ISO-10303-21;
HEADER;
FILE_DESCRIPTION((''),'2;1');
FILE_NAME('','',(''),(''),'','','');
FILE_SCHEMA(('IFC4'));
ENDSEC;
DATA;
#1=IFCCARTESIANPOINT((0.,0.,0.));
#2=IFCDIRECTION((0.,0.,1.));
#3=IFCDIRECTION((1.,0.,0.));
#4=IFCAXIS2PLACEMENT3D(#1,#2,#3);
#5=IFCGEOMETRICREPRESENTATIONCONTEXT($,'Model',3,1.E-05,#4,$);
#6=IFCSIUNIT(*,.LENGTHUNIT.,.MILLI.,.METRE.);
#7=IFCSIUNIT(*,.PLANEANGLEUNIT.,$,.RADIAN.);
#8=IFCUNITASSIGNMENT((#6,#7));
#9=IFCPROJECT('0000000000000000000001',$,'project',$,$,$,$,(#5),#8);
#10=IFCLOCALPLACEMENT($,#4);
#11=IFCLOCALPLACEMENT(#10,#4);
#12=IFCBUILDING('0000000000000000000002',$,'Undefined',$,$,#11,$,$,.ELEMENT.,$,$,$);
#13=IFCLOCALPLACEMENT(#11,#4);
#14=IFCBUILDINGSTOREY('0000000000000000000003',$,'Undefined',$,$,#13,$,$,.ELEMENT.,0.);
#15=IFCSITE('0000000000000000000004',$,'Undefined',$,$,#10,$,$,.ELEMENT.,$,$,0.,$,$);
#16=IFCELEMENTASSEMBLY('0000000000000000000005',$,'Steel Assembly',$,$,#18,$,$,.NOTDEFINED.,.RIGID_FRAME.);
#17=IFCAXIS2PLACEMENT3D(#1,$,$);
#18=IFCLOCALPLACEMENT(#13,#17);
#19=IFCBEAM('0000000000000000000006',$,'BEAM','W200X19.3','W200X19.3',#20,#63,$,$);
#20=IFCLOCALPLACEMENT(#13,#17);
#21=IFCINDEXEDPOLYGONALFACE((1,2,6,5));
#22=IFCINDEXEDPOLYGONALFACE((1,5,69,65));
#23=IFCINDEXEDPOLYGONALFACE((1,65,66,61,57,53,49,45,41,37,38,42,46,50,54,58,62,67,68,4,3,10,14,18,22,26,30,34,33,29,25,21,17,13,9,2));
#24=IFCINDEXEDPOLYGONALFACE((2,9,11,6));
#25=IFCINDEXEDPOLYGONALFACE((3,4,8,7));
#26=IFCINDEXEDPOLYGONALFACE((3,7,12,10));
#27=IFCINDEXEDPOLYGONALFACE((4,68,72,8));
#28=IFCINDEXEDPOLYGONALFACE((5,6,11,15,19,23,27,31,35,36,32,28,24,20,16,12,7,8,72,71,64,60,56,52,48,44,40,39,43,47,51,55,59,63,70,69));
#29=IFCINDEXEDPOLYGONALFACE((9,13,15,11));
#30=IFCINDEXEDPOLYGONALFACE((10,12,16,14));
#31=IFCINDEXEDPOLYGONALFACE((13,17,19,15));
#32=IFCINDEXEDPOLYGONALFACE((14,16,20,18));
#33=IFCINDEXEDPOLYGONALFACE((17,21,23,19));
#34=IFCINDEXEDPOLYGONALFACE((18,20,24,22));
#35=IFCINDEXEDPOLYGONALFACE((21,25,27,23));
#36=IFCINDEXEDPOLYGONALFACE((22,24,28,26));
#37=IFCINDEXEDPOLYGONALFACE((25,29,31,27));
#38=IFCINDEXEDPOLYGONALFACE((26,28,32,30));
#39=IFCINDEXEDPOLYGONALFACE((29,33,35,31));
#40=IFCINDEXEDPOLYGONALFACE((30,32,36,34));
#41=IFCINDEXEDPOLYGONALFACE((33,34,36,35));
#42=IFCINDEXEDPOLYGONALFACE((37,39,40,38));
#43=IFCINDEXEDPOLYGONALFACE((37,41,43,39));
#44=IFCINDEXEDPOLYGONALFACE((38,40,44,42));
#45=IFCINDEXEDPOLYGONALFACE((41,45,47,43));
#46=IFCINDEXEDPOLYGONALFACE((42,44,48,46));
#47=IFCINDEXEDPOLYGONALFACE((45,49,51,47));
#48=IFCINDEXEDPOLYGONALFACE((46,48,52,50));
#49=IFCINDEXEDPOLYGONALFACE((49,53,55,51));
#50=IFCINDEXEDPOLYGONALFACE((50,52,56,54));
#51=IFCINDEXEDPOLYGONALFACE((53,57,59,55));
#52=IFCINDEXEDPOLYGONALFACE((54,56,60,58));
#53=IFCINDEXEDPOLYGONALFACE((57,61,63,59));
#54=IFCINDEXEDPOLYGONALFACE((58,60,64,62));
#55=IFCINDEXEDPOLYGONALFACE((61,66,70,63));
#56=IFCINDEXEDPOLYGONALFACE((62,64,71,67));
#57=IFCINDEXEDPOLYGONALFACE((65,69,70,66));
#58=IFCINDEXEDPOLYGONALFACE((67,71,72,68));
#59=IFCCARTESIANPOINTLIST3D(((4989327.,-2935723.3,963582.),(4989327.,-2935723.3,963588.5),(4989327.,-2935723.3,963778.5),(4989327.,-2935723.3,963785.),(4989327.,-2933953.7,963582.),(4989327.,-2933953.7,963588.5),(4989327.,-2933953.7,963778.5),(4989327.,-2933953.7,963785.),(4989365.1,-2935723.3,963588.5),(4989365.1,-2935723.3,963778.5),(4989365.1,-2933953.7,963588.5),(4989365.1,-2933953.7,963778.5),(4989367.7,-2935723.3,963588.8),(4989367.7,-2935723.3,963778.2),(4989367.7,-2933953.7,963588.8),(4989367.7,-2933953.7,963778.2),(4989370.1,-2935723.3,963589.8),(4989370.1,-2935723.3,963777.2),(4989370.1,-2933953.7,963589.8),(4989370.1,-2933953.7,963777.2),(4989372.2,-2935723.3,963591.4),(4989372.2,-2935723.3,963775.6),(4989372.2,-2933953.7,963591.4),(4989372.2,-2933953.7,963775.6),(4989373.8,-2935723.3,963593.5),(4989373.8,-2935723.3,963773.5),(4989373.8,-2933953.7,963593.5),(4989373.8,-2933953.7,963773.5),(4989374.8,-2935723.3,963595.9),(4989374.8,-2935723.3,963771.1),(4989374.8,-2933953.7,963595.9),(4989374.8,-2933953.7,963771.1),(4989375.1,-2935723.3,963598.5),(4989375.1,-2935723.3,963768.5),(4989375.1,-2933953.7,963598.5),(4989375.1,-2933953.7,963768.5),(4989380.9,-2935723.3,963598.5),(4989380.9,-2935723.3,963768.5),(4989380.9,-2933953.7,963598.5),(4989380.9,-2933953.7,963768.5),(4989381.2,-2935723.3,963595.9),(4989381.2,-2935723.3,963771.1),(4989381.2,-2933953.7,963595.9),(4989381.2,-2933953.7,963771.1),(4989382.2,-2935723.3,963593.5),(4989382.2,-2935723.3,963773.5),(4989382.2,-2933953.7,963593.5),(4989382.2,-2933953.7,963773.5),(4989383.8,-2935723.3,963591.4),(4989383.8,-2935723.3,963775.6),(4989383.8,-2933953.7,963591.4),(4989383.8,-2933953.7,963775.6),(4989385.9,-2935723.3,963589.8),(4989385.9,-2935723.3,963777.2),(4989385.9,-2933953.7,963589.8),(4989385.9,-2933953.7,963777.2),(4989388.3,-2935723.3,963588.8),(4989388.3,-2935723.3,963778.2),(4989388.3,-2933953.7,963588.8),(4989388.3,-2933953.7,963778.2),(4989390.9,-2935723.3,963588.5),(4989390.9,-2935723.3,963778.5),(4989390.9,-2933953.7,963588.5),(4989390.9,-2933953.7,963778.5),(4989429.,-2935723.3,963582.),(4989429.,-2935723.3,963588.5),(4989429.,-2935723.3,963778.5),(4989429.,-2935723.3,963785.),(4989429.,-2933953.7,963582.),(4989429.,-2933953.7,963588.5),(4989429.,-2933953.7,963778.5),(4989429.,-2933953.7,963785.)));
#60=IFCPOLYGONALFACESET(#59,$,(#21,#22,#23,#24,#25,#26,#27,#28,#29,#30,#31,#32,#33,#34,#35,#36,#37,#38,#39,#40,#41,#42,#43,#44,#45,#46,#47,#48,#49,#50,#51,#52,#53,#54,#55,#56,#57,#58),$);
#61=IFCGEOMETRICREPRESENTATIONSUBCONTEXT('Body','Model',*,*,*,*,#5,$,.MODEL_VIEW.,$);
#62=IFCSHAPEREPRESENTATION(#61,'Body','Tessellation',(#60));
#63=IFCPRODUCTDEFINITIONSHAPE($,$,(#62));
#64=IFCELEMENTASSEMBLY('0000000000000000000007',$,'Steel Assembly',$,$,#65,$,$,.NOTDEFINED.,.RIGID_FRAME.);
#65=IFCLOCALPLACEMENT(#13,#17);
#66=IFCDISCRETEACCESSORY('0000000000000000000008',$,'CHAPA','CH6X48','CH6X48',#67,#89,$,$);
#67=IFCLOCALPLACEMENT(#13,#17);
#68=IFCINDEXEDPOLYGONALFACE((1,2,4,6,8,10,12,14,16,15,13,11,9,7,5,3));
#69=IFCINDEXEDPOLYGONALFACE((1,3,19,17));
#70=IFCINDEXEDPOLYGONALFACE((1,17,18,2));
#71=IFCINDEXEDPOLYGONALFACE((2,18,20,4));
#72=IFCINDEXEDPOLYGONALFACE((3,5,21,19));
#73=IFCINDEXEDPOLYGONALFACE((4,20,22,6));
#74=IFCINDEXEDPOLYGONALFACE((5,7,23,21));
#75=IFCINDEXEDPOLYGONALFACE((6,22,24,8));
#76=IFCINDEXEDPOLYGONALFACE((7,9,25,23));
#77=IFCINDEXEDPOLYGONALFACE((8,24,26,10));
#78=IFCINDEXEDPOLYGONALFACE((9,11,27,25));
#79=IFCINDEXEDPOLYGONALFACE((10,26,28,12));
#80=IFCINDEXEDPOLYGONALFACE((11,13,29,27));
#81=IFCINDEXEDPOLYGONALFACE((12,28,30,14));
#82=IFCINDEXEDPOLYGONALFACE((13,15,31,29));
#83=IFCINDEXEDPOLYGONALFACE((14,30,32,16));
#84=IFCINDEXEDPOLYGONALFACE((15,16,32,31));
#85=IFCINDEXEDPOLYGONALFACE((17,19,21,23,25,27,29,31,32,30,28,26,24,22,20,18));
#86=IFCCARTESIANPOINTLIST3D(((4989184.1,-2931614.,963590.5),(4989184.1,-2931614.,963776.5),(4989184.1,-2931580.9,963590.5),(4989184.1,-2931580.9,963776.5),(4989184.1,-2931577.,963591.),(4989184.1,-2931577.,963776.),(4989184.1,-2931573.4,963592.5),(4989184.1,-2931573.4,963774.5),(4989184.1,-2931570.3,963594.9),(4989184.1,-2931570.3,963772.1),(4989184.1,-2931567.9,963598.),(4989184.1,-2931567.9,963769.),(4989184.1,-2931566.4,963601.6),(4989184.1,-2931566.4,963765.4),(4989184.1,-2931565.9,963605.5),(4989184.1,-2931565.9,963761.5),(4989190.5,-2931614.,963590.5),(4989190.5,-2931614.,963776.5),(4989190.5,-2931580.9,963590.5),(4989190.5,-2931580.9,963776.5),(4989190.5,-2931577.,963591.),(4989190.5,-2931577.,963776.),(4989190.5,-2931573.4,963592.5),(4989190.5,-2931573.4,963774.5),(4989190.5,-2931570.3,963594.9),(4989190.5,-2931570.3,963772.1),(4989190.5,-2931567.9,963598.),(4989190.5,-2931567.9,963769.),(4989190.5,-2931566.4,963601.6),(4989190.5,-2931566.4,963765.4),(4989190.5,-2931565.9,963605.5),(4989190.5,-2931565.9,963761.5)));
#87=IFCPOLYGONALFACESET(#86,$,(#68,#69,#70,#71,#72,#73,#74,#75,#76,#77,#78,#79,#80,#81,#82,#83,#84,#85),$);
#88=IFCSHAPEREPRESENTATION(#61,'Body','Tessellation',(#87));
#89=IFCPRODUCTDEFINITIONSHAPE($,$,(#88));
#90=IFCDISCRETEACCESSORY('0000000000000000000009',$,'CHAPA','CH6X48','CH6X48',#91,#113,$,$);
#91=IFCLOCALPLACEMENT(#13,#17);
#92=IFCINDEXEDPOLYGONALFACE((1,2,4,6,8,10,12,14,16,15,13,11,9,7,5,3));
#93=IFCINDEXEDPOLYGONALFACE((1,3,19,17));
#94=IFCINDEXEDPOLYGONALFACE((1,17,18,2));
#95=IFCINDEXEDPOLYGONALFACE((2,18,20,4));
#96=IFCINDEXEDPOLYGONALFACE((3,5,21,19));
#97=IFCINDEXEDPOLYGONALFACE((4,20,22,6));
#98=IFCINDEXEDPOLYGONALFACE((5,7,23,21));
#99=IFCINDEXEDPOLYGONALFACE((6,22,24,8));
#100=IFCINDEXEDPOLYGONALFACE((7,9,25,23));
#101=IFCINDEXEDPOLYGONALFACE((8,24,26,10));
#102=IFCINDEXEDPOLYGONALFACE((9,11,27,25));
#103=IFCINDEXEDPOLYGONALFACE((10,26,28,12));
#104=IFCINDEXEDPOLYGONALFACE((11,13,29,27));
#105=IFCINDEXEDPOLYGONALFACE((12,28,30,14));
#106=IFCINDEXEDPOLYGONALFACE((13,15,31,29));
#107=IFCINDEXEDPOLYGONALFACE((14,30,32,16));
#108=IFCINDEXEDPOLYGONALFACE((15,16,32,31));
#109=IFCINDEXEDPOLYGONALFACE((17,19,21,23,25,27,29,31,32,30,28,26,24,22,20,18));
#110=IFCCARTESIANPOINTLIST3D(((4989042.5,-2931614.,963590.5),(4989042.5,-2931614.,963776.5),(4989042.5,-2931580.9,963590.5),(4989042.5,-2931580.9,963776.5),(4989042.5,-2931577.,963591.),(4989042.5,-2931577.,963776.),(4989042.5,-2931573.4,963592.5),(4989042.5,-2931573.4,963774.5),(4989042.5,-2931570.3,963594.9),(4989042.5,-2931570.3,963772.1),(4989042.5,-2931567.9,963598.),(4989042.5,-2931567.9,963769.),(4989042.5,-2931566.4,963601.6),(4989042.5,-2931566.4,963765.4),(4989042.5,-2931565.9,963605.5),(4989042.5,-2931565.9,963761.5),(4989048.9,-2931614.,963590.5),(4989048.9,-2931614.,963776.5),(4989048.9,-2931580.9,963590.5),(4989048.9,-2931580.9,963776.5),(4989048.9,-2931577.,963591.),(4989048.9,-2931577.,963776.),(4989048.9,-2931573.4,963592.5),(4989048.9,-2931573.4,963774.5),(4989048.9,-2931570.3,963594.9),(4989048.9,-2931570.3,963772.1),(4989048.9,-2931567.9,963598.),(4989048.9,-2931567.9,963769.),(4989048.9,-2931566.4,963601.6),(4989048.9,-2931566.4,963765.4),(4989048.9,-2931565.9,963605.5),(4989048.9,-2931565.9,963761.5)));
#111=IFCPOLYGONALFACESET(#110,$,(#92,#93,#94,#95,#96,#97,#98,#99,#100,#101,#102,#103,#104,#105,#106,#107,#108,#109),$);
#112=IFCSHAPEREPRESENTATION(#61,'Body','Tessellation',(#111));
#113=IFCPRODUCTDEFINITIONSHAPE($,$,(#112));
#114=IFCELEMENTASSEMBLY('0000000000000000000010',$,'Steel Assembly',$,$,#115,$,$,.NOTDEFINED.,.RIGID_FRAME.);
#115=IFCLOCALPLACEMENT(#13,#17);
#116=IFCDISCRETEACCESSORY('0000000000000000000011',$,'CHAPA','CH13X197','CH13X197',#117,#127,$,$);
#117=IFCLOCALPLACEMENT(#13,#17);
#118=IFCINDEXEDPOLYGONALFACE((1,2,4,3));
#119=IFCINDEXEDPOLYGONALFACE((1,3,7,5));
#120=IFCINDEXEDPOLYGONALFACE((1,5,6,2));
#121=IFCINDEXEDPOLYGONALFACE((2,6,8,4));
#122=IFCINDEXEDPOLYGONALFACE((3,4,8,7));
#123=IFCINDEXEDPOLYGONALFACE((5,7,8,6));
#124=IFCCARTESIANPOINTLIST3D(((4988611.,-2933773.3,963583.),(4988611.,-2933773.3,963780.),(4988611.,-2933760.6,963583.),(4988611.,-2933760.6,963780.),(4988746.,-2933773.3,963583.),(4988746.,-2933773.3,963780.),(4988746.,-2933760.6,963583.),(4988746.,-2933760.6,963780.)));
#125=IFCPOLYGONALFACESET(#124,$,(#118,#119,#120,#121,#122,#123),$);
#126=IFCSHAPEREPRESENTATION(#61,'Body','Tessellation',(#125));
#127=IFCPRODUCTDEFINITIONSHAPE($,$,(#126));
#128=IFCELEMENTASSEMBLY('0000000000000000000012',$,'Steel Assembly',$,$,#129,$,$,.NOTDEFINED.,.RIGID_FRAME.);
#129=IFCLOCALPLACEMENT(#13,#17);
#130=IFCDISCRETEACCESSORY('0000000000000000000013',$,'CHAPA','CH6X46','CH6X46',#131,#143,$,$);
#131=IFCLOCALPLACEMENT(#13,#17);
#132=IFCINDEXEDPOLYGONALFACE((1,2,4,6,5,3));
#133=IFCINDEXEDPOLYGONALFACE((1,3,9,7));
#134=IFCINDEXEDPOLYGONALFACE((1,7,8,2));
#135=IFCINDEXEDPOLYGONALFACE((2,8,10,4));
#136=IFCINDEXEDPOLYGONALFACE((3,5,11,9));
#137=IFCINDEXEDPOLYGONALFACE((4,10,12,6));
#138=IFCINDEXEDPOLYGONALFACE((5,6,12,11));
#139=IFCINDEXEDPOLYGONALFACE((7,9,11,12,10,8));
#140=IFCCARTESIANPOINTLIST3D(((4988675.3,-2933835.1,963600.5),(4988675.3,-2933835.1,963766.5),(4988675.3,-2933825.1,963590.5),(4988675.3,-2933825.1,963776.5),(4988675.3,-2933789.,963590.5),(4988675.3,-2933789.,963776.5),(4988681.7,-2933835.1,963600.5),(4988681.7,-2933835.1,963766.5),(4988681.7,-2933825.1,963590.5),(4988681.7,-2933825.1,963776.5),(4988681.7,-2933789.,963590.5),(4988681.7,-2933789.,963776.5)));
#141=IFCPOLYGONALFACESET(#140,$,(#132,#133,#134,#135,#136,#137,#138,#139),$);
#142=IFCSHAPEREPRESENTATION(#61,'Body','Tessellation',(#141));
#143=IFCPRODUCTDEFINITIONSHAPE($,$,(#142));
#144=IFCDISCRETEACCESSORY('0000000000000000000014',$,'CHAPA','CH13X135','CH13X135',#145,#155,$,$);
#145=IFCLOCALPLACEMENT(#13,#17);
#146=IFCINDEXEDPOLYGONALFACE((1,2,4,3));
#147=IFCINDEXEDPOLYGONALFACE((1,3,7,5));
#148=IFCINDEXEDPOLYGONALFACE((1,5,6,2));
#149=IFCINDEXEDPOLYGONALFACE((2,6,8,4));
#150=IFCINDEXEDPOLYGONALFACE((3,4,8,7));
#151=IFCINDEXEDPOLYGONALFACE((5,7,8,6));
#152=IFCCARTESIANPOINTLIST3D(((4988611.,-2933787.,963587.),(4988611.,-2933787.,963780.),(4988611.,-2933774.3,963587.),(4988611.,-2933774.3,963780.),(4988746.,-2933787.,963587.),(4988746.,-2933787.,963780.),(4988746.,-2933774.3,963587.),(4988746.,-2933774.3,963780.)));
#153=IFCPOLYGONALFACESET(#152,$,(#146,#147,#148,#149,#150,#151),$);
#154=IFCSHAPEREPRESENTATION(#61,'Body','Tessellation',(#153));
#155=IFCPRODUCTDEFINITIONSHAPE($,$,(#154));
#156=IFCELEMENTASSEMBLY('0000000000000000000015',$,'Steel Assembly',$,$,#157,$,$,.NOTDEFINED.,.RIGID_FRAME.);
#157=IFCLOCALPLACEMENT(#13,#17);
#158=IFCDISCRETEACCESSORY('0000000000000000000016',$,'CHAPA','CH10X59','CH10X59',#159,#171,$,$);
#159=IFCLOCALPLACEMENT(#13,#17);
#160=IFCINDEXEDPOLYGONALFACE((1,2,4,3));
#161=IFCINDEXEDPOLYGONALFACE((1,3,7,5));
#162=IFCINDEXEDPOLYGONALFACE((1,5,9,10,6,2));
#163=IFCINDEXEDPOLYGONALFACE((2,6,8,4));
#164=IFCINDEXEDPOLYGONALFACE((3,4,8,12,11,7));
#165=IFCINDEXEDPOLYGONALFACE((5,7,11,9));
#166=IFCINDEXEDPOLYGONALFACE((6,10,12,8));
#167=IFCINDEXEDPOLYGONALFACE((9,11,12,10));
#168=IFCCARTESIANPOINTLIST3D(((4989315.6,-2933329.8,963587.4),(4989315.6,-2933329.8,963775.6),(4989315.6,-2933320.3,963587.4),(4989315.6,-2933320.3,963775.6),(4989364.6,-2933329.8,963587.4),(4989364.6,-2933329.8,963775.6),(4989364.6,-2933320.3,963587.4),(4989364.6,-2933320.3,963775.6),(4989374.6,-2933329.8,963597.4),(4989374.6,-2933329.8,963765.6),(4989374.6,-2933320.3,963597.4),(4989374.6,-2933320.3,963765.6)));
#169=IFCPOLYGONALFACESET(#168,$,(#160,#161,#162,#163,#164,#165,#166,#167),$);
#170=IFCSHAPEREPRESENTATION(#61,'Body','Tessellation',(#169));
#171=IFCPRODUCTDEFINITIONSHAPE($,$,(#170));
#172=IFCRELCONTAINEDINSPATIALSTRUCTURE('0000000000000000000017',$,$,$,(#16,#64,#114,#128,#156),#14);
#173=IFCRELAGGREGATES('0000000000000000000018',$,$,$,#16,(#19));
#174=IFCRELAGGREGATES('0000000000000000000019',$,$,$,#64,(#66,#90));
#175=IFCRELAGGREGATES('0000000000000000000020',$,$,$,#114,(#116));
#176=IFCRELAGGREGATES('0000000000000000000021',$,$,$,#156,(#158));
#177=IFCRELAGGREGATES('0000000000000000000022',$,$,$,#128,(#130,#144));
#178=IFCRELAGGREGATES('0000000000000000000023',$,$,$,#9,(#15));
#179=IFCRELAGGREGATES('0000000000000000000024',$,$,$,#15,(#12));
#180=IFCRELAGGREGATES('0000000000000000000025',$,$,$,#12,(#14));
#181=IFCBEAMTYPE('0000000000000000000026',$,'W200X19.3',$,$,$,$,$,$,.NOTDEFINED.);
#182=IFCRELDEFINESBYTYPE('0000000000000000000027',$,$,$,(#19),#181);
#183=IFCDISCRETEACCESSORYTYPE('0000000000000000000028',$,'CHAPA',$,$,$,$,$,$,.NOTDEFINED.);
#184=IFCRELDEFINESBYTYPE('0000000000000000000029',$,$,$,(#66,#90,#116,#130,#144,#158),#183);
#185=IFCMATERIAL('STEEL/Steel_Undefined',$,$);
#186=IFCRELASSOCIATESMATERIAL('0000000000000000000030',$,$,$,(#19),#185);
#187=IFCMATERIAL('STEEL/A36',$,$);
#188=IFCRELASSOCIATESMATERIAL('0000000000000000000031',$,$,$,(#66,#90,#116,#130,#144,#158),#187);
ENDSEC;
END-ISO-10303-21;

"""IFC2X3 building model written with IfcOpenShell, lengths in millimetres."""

from ifc_helpers import new_model, si_unit, frame, frame_2d, origin_with_axes, origin_2d_with_axis, place, context, subcontext, project, spatial, polyline, circle_curve, parameter, trimmed, segment, composite_curve, i_section, outline, extrude, clip, halfspace, material, type_object, element, aggregate, save


model = new_model("IFC2X3")

# Units and contexts
model_context = context("Model", 3, precision=1e-05, world=origin_with_axes())
body_context = subcontext(model_context, "Body", "Model", "MODEL_VIEW")
ifc_project = project(units=[si_unit("LENGTHUNIT", "METRE", prefix="MILLI"), si_unit("PLANEANGLEUNIT", "RADIAN")], contexts=[model_context])

# Site, building, storey
site_placement = place(None, origin_with_axes())
site = spatial("IfcSite", under=ifc_project, at=site_placement, Name="Undefined", CompositionType="ELEMENT", RefElevation=0.0)
building_placement = place(site_placement, origin_with_axes())
building = spatial("IfcBuilding", under=site, at=building_placement, Name="Undefined", CompositionType="ELEMENT")
storey_placement = place(building_placement, origin_with_axes())
storey = spatial("IfcBuildingStorey", under=building, at=storey_placement, Name="Undefined", CompositionType="ELEMENT", Elevation=0.0)

# Shared definitions
ifc_material_1 = material(Name="STEEL/Steel_Undefined")

# Element assembly, beam
assembly_1_placement = place(storey_placement, origin_with_axes())
assembly_1 = element("IfcElementAssembly", 1, at=assembly_1_placement, inside=storey, Name="Steel Assembly", AssemblyPlace="NOTDEFINED", PredefinedType="RIGID_FRAME")
beam_type = type_object("IfcBeamType", Name="W200X19.3", PredefinedType="NOTDEFINED")
beam_placement = place(assembly_1_placement, frame((4989378.0, -2933838.5, 963683.5), z_axis=(0.0, 0.0, -1.0), x_axis=(0.0, -1.0, 0.0)))
beam = element("IfcBeam", 2, at=beam_placement, type_object=beam_type, material=ifc_material_1, Name="BEAM", Description="W200X19.3", ObjectType="W200X19.3", context=body_context, shape_type="Clipping", body=[
    clip(clip(clip(clip(extrude(i_section(OverallWidth=102.0, OverallDepth=203.0, WebThickness=5.8, FlangeThickness=6.5, FilletRadius=10.0, at=origin_2d_with_axis()), frame((1884.8, 0.0, 0.0), z_axis=(-1.0, 0.0, 0.0), x_axis=(0.0, -1.0, 0.0)), (0.0, 0.0, 1.0), 1769.6), halfspace(frame((112.5, -51.0, 101.5), z_axis=(-1.0, 0.0, 0.0), x_axis=(0.0, 0.0, -1.0)), False)), halfspace(frame((1887.5, 51.0, 101.5), z_axis=(1.0, 0.0, 0.0), x_axis=(0.0, 0.0, -1.0)), False)), halfspace(frame((1884.8, 0.0, 101.5), z_axis=(-1.0, 0.0, 0.0), x_axis=(0.0, -1.0, 0.0)), True)), halfspace(frame((115.2, 0.0, 101.5), z_axis=(1.0, 0.0, 0.0), x_axis=(0.0, 1.0, 0.0)), True)),
])
aggregate(assembly_1, [beam])

# Element assembly, discrete accessories
assembly_2_placement = place(storey_placement, origin_with_axes())
assembly_2 = element("IfcElementAssembly", 3, at=assembly_2_placement, inside=storey, Name="Steel Assembly", AssemblyPlace="NOTDEFINED", PredefinedType="RIGID_FRAME")
ifc_material_2 = material(Name="STEEL/A36")
discrete_accessory_type_1 = type_object("IfcDiscreteAccessoryType", Name="CHAPA")
discrete_accessory_1_placement = place(assembly_2_placement, frame((4989187.3, -2931614.0, 963590.5), z_axis=(1.0, 0.0, 0.0), x_axis=(0.0, 1.0, 0.0)))
discrete_accessory_1 = element("IfcDiscreteAccessory", 4, at=discrete_accessory_1_placement, type_object=discrete_accessory_type_1, material=ifc_material_2, Name="CHAPA", Description="CH6X48", ObjectType="CH6X48", context=body_context, shape_type="SweptSolid", body=[
    extrude(outline(composite_curve([segment(polyline([(0.0, 0.0), (33.1, 0.0)]), True, "CONTINUOUS"), segment(trimmed(circle_curve(frame_2d((33.1, 15.0), x_axis=(0.0, -1.0)), 15.0), [parameter(0.0)], [parameter(1.570796)], True, "PARAMETER"), True, "CONTINUOUS"), segment(polyline([(48.1, 15.0), (48.1, 171.0)]), True, "CONTINUOUS"), segment(trimmed(circle_curve(frame_2d((33.1, 171.0), x_axis=(1.0, 0.0)), 15.0), [parameter(0.0)], [parameter(1.570796)], True, "PARAMETER"), True, "CONTINUOUS"), segment(polyline([(33.1, 186.0), (0.0, 186.0), (0.0, 0.0)]), True, "DISCONTINUOUS")], self_intersect=False)), frame((0.0, 0.0, -3.2), z_axis=(0.0, 0.0, 1.0), x_axis=(1.0, 0.0, 0.0)), (0.0, 0.0, 1.0), 6.4),
])
discrete_accessory_2_placement = place(assembly_2_placement, frame((4989045.7, -2931614.0, 963590.5), z_axis=(1.0, 0.0, 0.0), x_axis=(0.0, 1.0, 0.0)))
discrete_accessory_2 = element("IfcDiscreteAccessory", 5, at=discrete_accessory_2_placement, type_object=discrete_accessory_type_1, material=ifc_material_2, Name="CHAPA", Description="CH6X48", ObjectType="CH6X48", context=body_context, shape_type="SweptSolid", body=[
    extrude(outline(composite_curve([segment(polyline([(0.0, 0.0), (33.1, 0.0)]), True, "CONTINUOUS"), segment(trimmed(circle_curve(frame_2d((33.1, 15.0), x_axis=(0.0, -1.0)), 15.0), [parameter(0.0)], [parameter(1.570796)], True, "PARAMETER"), True, "CONTINUOUS"), segment(polyline([(48.1, 15.0), (48.1, 171.0)]), True, "CONTINUOUS"), segment(trimmed(circle_curve(frame_2d((33.1, 171.0), x_axis=(1.0, 0.0)), 15.0), [parameter(0.0)], [parameter(1.570796)], True, "PARAMETER"), True, "CONTINUOUS"), segment(polyline([(33.1, 186.0), (0.0, 186.0), (0.0, 0.0)]), True, "DISCONTINUOUS")], self_intersect=False)), frame((0.0, 0.0, -3.2), z_axis=(0.0, 0.0, 1.0), x_axis=(1.0, 0.0, 0.0)), (0.0, 0.0, 1.0), 6.4),
])
aggregate(assembly_2, [discrete_accessory_1, discrete_accessory_2])

# Element assembly, discrete accessory
assembly_3_placement = place(storey_placement, origin_with_axes())
assembly_3 = element("IfcElementAssembly", 6, at=assembly_3_placement, inside=storey, Name="Steel Assembly", AssemblyPlace="NOTDEFINED", PredefinedType="RIGID_FRAME")
discrete_accessory_3_placement = place(assembly_3_placement, frame((4988678.5, -2933767.0, 963780.0), z_axis=(0.0, 1.0, 0.0), x_axis=(0.0, 0.0, -1.0)))
discrete_accessory_3 = element("IfcDiscreteAccessory", 7, at=discrete_accessory_3_placement, type_object=discrete_accessory_type_1, material=ifc_material_2, Name="CHAPA", Description="CH13X197", ObjectType="CH13X197", context=body_context, shape_type="SweptSolid", body=[
    extrude(outline(polyline([(197.0, 67.5), (197.0, -67.5), (0.0, -67.5), (0.0, 67.5), (197.0, 67.5)])), frame((0.0, 0.0, -6.3), z_axis=(0.0, 0.0, 1.0), x_axis=(1.0, 0.0, 0.0)), (0.0, 0.0, 1.0), 12.7),
])
aggregate(assembly_3, [discrete_accessory_3])

# Element assemblies, discrete accessories
assembly_4_placement = place(storey_placement, origin_with_axes())
assembly_4 = element("IfcElementAssembly", 8, at=assembly_4_placement, inside=storey, Name="Steel Assembly", AssemblyPlace="NOTDEFINED", PredefinedType="RIGID_FRAME")
discrete_accessory_4_placement = place(assembly_4_placement, frame((4988678.5, -2933835.1, 963776.5), z_axis=(-1.0, 0.0, 0.0), x_axis=(0.0, 1.0, 0.0)))
discrete_accessory_4 = element("IfcDiscreteAccessory", 9, at=discrete_accessory_4_placement, type_object=discrete_accessory_type_1, material=ifc_material_2, Name="CHAPA", Description="CH6X46", ObjectType="CH6X46", context=body_context, shape_type="SweptSolid", body=[
    extrude(outline(polyline([(0.0, 10.0), (10.0, 0.0), (46.1, 0.0), (46.1, 186.0), (10.0, 186.0), (0.0, 176.0), (0.0, 10.0)])), frame((0.0, 0.0, -3.2), z_axis=(0.0, 0.0, 1.0), x_axis=(1.0, 0.0, 0.0)), (0.0, 0.0, 1.0), 6.4),
])
discrete_accessory_5_placement = place(assembly_4_placement, frame((4988678.5, -2933780.7, 963780.0), z_axis=(0.0, 1.0, 0.0), x_axis=(0.0, 0.0, -1.0)))
discrete_accessory_5 = element("IfcDiscreteAccessory", 10, at=discrete_accessory_5_placement, type_object=discrete_accessory_type_1, material=ifc_material_2, Name="CHAPA", Description="CH13X135", ObjectType="CH13X135", context=body_context, shape_type="SweptSolid", body=[
    extrude(outline(polyline([(193.0, 67.5), (193.0, -67.5), (0.0, -67.5), (0.0, 67.5), (193.0, 67.5)])), frame((0.0, 0.0, -6.3), z_axis=(0.0, 0.0, 1.0), x_axis=(1.0, 0.0, 0.0)), (0.0, 0.0, 1.0), 12.7),
])
assembly_5_placement = place(storey_placement, origin_with_axes())
assembly_5 = element("IfcElementAssembly", 11, at=assembly_5_placement, inside=storey, Name="Steel Assembly", AssemblyPlace="NOTDEFINED", PredefinedType="RIGID_FRAME")
discrete_accessory_6_placement = place(assembly_5_placement, frame((4989374.6, -2933325.0, 963587.4), z_axis=(0.0, 1.0, 0.0), x_axis=(-1.0, 0.0, 0.0)))
discrete_accessory_6 = element("IfcDiscreteAccessory", 12, at=discrete_accessory_6_placement, type_object=discrete_accessory_type_1, material=ifc_material_2, Name="CHAPA", Description="CH10X59", ObjectType="CH10X59", context=body_context, shape_type="SweptSolid", body=[
    extrude(outline(polyline([(0.0, 10.0), (10.0, 0.0), (59.0, 0.0), (59.0, 188.2), (10.0, 188.2), (0.0, 178.2), (0.0, 10.0)])), frame((0.0, 0.0, -4.8), z_axis=(0.0, 0.0, 1.0), x_axis=(1.0, 0.0, 0.0)), (0.0, 0.0, 1.0), 9.5),
])
aggregate(assembly_5, [discrete_accessory_6])

aggregate(assembly_4, [discrete_accessory_4, discrete_accessory_5])

save(model, "model.ifc")
